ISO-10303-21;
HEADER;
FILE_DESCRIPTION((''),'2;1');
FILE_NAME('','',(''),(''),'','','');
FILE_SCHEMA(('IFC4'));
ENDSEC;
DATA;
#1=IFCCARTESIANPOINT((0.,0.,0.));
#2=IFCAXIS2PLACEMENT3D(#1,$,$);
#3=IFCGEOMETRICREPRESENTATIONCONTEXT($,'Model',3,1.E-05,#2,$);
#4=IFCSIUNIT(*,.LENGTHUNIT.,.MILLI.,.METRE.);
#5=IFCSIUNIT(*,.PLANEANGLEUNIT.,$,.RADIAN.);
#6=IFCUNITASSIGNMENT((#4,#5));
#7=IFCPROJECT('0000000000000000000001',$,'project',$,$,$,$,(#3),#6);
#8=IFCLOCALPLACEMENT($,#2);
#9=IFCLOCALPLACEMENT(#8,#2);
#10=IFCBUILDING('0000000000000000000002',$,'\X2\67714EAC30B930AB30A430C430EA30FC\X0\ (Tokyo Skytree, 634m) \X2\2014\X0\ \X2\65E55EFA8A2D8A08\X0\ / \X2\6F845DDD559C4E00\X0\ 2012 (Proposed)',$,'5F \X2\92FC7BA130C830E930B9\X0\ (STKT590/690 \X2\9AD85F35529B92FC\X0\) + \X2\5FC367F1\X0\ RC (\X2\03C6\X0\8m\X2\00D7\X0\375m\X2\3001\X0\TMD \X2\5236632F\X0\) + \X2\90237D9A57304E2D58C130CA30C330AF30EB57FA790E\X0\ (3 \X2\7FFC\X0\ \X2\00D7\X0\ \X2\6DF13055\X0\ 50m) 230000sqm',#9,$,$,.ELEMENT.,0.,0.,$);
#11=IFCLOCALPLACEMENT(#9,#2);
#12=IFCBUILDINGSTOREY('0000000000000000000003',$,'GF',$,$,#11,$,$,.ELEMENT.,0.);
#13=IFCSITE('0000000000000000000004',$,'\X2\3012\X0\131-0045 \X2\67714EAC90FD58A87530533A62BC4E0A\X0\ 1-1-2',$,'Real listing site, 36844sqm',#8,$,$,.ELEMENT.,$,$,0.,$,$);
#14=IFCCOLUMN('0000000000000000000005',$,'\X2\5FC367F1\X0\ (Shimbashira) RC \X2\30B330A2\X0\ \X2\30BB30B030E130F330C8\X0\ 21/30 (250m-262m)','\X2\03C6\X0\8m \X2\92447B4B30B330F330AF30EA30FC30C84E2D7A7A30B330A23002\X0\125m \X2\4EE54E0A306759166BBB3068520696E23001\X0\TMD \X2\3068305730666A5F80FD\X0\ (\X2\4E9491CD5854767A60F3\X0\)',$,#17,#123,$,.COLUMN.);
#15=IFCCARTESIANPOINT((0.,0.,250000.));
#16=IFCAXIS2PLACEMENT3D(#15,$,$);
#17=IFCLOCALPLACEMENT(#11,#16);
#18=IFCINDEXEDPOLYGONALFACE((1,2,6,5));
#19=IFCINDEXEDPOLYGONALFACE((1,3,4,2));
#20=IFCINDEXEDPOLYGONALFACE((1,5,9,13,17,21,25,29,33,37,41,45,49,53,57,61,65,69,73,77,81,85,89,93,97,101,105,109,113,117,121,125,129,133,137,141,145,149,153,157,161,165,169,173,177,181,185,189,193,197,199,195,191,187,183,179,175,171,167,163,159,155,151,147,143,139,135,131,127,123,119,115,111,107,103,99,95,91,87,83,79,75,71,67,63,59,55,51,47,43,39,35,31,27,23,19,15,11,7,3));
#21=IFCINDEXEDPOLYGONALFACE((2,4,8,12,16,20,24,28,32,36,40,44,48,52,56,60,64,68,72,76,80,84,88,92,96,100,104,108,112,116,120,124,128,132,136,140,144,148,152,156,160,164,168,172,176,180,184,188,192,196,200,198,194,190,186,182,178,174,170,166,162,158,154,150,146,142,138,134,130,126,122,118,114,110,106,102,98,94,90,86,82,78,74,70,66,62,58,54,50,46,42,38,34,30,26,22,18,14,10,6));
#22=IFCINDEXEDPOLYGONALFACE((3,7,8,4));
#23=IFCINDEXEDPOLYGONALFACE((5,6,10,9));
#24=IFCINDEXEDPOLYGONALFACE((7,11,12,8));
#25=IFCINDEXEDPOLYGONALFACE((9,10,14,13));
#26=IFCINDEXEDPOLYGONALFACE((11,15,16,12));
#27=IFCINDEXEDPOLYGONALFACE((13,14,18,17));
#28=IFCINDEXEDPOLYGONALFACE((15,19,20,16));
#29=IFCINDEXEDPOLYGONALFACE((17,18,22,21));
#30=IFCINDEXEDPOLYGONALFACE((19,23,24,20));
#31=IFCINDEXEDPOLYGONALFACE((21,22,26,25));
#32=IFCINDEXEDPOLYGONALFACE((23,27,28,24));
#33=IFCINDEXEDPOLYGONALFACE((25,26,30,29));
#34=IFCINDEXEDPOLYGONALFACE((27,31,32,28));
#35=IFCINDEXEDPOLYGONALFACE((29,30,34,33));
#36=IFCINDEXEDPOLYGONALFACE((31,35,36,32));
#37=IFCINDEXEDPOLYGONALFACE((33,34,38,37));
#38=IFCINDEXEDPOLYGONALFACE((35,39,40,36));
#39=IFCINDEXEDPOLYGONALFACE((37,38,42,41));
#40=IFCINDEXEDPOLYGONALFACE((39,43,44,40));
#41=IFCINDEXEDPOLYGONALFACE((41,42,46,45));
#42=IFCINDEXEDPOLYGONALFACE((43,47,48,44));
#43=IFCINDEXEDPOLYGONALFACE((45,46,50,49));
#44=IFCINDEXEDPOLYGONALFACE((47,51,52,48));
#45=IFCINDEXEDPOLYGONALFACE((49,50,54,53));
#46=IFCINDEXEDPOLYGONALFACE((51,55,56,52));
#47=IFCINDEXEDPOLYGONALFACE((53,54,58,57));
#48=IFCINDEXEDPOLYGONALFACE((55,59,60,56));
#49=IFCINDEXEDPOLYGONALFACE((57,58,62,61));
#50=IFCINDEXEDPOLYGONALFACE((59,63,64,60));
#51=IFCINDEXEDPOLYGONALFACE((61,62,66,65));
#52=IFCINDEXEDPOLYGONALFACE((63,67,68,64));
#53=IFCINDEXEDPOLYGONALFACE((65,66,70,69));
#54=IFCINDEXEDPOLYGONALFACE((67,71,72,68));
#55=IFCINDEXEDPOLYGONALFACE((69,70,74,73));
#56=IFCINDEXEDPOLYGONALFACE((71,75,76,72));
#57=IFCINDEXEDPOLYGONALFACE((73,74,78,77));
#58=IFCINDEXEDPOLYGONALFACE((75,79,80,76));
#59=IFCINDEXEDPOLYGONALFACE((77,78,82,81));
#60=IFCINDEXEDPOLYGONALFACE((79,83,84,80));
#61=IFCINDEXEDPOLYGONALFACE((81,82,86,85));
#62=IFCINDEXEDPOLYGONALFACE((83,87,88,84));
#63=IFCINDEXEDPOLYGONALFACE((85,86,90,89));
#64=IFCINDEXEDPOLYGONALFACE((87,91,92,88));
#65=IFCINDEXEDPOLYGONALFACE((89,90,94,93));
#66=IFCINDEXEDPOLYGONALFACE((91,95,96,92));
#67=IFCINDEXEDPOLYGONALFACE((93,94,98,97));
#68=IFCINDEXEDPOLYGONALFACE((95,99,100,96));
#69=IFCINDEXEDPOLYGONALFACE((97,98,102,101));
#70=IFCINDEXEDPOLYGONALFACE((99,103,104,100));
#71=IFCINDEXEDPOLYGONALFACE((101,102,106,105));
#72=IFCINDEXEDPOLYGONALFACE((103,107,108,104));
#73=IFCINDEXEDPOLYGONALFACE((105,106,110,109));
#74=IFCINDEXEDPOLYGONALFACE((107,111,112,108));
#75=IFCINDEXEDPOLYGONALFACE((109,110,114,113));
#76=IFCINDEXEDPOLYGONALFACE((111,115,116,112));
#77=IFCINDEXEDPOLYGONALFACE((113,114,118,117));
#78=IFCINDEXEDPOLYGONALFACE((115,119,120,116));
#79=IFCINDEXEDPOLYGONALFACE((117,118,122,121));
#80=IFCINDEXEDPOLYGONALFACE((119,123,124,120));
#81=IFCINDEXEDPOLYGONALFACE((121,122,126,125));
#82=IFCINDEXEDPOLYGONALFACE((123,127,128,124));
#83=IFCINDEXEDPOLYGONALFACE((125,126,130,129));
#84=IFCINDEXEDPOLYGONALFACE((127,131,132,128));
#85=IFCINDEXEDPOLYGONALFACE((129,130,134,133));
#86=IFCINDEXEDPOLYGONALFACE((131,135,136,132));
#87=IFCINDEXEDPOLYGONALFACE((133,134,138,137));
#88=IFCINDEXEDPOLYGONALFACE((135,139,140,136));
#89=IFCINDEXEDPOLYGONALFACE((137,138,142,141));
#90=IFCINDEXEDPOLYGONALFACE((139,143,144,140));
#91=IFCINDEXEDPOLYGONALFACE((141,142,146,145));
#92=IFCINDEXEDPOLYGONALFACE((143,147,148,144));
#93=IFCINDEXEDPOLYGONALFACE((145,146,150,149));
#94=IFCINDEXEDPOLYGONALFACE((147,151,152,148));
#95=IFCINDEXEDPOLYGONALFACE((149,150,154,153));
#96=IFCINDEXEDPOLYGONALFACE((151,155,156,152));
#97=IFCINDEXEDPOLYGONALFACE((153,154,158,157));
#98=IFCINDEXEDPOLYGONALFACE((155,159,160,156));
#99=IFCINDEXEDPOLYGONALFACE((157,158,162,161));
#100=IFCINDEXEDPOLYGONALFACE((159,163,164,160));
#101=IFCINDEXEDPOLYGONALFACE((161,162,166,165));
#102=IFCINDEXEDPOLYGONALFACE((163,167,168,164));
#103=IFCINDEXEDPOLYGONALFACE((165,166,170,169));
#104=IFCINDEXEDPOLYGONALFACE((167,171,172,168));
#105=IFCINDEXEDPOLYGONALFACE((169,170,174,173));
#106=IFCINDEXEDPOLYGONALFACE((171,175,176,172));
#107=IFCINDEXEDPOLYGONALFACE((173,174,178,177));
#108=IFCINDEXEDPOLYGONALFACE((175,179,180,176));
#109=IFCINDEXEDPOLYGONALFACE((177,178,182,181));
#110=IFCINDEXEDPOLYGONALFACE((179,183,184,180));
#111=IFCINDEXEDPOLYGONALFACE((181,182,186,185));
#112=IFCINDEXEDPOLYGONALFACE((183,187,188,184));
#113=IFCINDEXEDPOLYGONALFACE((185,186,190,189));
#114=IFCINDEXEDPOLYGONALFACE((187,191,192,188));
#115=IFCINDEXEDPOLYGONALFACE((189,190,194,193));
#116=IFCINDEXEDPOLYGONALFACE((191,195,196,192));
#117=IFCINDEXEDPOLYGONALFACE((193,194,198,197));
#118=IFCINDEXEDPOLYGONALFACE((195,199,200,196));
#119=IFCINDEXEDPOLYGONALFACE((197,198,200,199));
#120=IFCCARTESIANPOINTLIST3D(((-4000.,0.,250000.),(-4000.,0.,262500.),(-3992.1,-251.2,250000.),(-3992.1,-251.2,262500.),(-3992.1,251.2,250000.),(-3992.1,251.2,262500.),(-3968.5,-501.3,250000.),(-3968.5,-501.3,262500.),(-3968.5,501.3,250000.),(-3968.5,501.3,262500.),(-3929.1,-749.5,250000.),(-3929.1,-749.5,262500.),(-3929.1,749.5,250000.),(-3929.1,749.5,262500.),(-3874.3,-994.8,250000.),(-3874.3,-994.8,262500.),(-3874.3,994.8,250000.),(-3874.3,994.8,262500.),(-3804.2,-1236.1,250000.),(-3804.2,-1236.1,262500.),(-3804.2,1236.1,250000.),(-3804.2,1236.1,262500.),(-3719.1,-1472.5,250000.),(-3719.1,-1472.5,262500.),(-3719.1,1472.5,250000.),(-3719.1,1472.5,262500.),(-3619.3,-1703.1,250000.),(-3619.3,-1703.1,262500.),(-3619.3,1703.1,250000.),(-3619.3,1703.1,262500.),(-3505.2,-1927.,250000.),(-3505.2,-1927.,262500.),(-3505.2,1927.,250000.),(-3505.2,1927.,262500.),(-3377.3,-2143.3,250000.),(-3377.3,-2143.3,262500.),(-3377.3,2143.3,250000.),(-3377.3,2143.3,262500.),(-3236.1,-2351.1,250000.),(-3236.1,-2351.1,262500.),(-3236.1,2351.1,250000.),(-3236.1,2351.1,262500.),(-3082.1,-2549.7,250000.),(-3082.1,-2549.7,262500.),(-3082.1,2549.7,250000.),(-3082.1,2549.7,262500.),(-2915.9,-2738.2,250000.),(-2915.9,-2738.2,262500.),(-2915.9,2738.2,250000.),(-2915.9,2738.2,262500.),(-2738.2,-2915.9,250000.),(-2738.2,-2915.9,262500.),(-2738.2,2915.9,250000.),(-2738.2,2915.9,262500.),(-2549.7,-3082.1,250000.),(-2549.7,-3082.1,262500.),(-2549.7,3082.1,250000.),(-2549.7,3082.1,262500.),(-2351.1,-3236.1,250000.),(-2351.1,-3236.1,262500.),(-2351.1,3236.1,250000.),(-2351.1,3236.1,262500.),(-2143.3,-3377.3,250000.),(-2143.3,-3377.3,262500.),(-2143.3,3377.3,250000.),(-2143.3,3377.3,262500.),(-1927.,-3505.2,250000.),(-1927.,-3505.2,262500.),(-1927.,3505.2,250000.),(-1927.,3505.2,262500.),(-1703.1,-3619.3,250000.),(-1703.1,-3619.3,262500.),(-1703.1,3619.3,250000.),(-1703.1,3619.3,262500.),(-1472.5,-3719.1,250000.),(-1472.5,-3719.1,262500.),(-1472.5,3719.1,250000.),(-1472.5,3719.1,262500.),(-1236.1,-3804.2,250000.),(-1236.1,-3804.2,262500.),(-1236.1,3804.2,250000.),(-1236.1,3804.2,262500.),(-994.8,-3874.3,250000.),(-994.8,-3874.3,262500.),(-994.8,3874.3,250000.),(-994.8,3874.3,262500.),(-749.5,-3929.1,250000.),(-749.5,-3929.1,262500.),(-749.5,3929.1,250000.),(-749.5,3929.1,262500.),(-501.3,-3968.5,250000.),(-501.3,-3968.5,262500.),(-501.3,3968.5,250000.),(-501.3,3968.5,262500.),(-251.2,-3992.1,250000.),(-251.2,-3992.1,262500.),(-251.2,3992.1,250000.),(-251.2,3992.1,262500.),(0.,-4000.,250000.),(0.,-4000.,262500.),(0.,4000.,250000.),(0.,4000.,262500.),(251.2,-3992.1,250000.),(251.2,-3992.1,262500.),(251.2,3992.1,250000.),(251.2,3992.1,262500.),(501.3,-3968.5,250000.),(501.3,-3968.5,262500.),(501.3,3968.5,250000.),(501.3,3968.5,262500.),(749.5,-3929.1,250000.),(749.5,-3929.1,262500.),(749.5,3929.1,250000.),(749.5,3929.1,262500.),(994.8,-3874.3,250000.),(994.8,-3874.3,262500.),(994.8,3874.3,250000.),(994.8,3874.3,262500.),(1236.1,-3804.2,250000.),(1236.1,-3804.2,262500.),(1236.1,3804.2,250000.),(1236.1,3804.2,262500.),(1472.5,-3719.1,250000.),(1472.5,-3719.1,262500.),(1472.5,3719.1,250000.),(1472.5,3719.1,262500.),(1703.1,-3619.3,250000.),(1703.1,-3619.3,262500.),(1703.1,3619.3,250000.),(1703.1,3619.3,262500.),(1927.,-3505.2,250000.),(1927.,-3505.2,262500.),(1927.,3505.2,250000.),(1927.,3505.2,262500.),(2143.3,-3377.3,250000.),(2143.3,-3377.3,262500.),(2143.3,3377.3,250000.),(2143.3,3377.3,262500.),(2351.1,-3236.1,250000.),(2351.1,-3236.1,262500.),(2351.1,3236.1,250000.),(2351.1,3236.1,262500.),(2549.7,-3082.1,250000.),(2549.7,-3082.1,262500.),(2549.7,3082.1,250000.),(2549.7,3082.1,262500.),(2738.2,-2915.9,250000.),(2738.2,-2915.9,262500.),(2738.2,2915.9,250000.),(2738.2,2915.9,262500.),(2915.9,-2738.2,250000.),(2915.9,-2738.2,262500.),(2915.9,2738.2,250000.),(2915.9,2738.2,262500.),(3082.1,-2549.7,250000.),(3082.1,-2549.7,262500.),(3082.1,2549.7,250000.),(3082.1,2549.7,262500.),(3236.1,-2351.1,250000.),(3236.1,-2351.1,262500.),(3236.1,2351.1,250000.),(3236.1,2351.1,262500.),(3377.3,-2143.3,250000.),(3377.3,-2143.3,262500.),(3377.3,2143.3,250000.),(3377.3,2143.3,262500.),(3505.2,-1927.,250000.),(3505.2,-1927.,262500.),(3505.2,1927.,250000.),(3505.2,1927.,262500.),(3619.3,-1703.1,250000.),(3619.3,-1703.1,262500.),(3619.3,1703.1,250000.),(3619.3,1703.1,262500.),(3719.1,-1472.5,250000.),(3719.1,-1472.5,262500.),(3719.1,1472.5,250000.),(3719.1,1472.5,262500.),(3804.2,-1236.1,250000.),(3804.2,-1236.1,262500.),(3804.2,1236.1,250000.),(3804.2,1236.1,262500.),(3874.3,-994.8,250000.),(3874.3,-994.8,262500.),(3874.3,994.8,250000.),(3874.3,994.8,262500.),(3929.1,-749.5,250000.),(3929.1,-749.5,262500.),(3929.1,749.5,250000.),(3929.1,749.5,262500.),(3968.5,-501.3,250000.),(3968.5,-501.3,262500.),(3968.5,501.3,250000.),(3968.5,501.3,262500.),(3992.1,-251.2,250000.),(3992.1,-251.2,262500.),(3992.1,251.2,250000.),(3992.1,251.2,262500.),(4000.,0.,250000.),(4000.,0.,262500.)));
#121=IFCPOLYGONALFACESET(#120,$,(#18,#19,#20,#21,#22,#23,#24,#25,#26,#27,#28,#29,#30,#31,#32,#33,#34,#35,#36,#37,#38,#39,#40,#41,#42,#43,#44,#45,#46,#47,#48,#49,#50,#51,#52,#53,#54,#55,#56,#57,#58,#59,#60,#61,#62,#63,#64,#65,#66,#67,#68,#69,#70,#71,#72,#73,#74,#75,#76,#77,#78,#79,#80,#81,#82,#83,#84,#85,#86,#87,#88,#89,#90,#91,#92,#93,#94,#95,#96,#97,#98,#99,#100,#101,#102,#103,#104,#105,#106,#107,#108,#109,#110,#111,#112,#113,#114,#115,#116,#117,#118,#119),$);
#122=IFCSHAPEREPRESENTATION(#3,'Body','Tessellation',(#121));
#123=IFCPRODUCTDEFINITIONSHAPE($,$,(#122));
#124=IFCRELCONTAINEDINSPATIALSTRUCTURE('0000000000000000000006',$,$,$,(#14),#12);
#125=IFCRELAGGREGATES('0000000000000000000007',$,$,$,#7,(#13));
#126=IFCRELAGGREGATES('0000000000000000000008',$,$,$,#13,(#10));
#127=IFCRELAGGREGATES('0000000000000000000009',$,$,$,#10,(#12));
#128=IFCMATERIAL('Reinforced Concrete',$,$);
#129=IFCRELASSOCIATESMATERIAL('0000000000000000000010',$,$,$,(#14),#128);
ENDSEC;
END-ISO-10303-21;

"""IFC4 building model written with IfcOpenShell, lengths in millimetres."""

from ifc_helpers import new_model, si_unit, frame, origin, origin_2d, place, context, project, spatial, circle, extrude, material, element, save


model = new_model("IFC4")

# Units and contexts
model_context = context("Model", 3, precision=1e-05, world=origin())
ifc_project = project(units=[si_unit("LENGTHUNIT", "METRE", prefix="MILLI"), si_unit("PLANEANGLEUNIT", "RADIAN")], contexts=[model_context])

# Site, building, storey
site_placement = place(None, origin())
site = spatial("IfcSite", under=ifc_project, at=site_placement, Name="〒131-0045 東京都墨田区押上 1-1-2", ObjectType="Real listing site, 36844sqm", CompositionType="ELEMENT", RefElevation=0.0)
building_placement = place(site_placement, origin())
building = spatial("IfcBuilding", under=site, at=building_placement, Name="東京スカイツリー (Tokyo Skytree, 634m) — 日建設計 / 澄川喜一 2012 (Proposed)", ObjectType="5F 鋼管トラス (STKT590/690 高張力鋼) + 心柱 RC (φ8m×375m、TMD 制振) + 連続地中壁ナックル基礎 (3 翼 × 深さ 50m) 230000sqm", CompositionType="ELEMENT", ElevationOfRefHeight=0.0, ElevationOfTerrain=0.0)
storey_placement = place(building_placement, origin())
storey = spatial("IfcBuildingStorey", under=building, at=storey_placement, Name="GF", CompositionType="ELEMENT", Elevation=0.0)

# Column
ifc_material_1 = material(Name="Reinforced Concrete")
column_1_placement = place(storey_placement, frame((0.0, 0.0, 250000.0)))
element("IfcColumn", 1, at=column_1_placement, inside=storey, material=ifc_material_1, Name="心柱 (Shimbashira) RC コア セグメント 21/30 (250m-262m)", Description="φ8m 鉄筋コンクリート中空コア。125m 以上で外殻と分離、TMD として機能 (五重塔発想)", PredefinedType="COLUMN", context=model_context, shape_type="SweptSolid", body=[
    extrude(circle(Radius=4000.0, at=origin_2d()), frame((0.0, 0.0, 250000.0)), (0.0, 0.0, 1.0), 12500.0),
])

save(model, "model.ifc")
